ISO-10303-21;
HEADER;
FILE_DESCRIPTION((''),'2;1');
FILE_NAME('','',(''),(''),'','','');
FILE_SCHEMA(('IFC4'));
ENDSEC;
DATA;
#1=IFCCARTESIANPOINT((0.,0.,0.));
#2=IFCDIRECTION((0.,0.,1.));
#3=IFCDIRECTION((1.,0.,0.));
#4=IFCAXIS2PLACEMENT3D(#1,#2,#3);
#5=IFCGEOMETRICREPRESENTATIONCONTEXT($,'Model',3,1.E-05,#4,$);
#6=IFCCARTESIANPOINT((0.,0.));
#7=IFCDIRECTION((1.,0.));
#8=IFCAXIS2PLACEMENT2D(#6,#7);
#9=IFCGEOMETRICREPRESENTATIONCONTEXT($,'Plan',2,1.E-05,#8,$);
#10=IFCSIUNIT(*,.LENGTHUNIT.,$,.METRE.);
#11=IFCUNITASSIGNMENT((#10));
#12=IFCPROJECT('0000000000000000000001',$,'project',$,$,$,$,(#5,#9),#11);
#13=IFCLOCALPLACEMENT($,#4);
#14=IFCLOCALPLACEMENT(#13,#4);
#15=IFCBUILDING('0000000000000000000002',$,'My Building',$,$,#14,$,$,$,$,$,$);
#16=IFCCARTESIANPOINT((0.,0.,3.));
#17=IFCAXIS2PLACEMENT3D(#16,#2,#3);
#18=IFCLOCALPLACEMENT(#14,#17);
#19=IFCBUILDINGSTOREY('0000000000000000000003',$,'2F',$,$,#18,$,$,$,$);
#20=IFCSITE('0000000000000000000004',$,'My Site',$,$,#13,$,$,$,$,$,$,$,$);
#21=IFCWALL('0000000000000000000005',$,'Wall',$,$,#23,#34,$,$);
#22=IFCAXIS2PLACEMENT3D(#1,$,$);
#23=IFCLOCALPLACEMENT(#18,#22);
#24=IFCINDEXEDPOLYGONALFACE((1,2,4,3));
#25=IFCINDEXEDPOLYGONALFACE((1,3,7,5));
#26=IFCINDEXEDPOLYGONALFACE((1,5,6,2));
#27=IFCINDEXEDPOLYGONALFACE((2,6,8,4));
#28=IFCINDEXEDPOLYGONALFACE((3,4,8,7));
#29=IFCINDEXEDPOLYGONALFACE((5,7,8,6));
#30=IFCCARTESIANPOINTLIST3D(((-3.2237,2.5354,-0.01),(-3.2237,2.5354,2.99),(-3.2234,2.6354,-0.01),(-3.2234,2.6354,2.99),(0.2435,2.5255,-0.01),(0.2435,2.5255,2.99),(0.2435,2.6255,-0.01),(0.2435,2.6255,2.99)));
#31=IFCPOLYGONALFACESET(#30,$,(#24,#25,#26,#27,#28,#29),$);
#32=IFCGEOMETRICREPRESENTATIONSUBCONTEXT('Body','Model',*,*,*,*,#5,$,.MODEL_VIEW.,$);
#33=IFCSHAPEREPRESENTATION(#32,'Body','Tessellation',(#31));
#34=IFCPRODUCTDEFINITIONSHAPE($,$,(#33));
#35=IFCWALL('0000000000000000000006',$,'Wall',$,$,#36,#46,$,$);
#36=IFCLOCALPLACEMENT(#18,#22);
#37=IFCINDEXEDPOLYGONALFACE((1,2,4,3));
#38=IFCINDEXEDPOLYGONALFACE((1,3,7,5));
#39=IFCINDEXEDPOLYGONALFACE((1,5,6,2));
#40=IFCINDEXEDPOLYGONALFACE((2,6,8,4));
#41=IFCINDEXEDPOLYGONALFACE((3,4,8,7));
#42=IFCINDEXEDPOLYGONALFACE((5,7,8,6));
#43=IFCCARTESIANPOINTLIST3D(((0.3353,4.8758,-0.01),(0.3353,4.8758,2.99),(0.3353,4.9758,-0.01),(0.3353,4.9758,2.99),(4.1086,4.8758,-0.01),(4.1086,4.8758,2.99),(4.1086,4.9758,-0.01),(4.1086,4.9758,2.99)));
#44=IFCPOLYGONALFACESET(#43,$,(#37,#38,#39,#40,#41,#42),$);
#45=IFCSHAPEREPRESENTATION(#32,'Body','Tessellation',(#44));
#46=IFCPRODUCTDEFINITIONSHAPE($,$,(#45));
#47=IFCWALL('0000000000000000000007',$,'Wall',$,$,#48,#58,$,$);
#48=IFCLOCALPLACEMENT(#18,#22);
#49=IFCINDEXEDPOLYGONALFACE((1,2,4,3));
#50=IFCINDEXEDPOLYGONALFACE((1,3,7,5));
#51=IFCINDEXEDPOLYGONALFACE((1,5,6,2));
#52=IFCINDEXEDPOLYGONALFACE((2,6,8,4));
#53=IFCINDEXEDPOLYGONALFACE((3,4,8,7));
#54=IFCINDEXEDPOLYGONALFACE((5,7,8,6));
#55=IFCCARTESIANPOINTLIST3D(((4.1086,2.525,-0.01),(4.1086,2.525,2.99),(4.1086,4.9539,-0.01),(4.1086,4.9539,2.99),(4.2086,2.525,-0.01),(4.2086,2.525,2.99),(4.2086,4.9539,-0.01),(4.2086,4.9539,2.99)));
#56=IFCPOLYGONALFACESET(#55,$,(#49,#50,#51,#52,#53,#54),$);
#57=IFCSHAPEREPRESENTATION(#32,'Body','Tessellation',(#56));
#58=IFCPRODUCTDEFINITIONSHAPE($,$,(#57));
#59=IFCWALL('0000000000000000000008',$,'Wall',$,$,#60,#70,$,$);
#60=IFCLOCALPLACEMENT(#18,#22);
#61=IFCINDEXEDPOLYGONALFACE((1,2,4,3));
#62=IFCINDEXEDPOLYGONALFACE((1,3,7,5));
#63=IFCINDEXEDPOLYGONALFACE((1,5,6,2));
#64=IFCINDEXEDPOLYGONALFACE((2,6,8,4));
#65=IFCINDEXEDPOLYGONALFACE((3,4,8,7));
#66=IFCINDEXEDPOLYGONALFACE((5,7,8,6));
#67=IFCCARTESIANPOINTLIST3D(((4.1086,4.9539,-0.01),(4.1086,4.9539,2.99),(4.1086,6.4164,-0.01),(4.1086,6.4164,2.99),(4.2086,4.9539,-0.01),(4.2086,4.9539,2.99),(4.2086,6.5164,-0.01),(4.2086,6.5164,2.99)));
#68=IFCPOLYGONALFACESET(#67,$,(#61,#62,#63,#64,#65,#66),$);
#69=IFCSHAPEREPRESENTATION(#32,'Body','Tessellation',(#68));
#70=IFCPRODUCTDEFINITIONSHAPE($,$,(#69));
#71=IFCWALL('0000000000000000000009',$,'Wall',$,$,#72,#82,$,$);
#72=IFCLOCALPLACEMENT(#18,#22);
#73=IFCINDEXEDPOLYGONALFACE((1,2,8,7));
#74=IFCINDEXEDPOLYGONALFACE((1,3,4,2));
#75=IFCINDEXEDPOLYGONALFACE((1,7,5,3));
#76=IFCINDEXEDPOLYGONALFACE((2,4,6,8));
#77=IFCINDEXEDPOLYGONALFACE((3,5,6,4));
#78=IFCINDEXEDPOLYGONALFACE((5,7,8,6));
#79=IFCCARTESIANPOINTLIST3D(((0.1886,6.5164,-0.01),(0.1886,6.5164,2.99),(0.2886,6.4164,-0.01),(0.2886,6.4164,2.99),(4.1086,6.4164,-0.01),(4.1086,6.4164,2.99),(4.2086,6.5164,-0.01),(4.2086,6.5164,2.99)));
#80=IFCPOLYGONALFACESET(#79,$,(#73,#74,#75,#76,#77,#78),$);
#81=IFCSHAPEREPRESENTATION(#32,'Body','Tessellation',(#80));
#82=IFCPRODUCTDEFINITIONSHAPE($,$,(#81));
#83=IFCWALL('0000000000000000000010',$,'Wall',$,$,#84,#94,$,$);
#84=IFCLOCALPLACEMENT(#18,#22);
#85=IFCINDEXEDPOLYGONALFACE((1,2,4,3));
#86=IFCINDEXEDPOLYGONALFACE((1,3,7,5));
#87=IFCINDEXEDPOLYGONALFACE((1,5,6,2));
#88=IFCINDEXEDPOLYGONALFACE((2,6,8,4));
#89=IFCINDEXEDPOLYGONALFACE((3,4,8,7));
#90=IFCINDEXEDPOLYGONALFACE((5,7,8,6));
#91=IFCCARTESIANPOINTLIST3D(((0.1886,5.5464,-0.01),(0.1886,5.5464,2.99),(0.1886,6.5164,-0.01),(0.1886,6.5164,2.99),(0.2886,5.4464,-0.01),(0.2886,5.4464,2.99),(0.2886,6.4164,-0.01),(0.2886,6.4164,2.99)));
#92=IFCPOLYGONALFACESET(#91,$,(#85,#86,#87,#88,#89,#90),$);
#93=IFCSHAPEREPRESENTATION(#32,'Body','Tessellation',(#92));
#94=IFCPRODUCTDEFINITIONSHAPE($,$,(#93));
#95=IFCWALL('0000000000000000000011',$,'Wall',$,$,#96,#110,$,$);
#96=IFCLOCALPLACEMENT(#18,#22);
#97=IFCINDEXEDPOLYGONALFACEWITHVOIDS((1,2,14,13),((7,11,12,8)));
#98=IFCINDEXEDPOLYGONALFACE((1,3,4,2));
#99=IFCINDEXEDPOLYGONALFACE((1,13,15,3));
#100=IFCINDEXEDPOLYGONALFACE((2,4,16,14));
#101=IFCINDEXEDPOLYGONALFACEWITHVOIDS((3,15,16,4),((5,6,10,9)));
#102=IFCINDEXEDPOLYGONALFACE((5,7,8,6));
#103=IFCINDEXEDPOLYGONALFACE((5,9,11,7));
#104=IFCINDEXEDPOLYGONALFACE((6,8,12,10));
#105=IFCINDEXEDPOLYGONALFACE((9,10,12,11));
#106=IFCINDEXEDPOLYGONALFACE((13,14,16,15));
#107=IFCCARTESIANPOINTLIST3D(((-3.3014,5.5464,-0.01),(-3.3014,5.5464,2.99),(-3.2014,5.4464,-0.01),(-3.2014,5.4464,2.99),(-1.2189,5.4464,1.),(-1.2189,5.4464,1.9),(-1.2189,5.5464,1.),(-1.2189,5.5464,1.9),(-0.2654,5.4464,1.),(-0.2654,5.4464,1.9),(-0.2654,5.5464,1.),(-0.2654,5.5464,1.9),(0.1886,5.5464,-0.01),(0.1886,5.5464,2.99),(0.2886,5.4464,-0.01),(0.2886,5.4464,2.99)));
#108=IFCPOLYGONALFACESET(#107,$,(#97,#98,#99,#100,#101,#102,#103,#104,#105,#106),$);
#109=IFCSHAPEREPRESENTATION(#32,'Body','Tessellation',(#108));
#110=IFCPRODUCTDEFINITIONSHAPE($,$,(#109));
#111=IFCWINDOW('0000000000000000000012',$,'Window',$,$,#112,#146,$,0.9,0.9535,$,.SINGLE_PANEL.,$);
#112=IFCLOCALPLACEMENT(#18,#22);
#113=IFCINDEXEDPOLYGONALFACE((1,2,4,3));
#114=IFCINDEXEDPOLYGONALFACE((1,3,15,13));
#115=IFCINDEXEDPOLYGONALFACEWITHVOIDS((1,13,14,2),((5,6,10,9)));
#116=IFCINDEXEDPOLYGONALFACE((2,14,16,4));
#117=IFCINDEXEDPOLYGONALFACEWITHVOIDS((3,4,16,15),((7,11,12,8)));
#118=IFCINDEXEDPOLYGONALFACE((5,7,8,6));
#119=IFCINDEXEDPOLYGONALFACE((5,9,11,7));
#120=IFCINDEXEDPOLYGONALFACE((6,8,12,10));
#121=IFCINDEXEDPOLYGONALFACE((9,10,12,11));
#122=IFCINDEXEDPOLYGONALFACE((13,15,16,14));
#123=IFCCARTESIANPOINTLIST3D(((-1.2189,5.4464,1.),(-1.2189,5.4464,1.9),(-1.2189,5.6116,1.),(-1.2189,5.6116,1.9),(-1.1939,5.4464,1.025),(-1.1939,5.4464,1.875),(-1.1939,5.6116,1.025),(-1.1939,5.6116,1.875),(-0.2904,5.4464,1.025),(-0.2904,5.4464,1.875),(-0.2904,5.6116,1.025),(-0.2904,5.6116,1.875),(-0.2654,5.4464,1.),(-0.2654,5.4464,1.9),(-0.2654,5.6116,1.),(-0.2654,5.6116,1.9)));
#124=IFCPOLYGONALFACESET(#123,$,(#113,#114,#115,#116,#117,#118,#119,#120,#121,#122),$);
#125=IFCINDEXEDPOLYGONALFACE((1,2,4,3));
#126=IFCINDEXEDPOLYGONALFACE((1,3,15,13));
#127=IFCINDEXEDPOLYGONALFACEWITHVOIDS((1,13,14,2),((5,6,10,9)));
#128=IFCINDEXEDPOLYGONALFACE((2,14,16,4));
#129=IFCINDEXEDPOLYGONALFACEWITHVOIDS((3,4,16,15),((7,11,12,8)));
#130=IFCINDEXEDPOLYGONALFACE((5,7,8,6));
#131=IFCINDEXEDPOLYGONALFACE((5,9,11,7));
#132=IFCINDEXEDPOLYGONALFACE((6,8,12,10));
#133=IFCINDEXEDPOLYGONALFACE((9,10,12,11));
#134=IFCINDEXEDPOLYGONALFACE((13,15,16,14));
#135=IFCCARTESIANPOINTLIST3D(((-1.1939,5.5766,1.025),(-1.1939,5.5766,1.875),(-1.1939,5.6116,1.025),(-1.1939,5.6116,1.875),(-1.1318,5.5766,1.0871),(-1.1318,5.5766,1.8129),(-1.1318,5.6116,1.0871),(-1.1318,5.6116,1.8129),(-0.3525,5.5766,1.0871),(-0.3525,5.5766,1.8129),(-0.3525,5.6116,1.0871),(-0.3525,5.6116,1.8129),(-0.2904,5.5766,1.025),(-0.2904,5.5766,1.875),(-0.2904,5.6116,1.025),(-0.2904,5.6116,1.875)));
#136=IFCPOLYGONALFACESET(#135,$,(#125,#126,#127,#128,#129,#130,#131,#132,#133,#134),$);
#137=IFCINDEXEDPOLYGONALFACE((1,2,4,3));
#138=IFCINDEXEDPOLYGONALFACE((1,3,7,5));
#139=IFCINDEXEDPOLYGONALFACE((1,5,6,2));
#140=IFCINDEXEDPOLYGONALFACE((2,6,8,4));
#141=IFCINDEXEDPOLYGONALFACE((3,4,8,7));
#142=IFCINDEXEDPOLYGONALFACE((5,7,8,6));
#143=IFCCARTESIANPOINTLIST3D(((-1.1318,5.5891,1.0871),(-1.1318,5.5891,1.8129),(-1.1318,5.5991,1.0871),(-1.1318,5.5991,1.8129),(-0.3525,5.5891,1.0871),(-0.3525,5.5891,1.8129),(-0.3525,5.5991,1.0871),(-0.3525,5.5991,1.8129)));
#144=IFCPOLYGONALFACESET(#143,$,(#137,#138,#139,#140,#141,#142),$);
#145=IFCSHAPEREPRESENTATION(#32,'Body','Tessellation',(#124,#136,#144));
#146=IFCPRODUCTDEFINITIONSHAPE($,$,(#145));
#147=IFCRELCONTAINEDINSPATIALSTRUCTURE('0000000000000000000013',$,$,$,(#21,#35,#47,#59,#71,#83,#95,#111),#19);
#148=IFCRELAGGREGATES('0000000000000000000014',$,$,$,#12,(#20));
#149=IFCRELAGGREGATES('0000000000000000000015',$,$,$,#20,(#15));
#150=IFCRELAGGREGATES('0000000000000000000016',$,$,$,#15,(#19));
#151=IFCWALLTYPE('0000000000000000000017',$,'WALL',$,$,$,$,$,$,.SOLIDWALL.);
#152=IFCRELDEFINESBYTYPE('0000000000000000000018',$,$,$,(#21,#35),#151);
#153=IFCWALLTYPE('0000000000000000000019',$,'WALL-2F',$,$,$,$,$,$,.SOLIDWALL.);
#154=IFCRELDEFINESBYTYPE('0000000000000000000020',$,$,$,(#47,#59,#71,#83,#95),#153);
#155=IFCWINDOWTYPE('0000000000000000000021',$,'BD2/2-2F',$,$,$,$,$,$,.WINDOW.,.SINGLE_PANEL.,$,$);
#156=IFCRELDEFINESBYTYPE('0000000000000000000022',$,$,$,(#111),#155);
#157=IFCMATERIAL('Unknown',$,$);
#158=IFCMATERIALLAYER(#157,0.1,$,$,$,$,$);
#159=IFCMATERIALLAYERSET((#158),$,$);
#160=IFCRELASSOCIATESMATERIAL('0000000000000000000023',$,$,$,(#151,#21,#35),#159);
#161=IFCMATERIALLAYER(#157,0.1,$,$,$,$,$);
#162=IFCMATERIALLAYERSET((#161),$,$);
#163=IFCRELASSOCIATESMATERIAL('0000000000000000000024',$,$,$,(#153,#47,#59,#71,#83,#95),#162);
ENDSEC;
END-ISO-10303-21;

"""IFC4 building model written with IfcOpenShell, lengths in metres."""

from ifc_helpers import new_model, entity, si_unit, frame, origin_with_axes, origin_2d_with_axis, place, context, subcontext, project, spatial, line, indexed_curve, outline, extrude, shape, source, transform, mapped, material, layer, layer_set, layer_usage, type_object, type_shapes, element, fill, save


model = new_model("IFC4")

# Units and contexts
model_context = context("Model", 3, precision=1e-05, world=origin_with_axes())
plan_context = context("Plan", 2, precision=1e-05, world=origin_2d_with_axis())
body_context_1 = subcontext(model_context, "Body", "Model", "MODEL_VIEW")
body_context_2 = subcontext(plan_context, "Body", "Plan", "PLAN_VIEW")
ifc_project = project(units=[si_unit("LENGTHUNIT", "METRE")], contexts=[model_context, plan_context])

# Site, building, storey
site_placement = place(None, origin_with_axes())
site = spatial("IfcSite", under=ifc_project, at=site_placement, Name="My Site")
building_placement = place(site_placement, origin_with_axes())
building = spatial("IfcBuilding", under=site, at=building_placement, Name="My Building")
storey_placement = place(building_placement, frame((0.0, 0.0, 3.0), z_axis=(0.0, 0.0, 1.0), x_axis=(1.0, 0.0, 0.0)))
storey = spatial("IfcBuildingStorey", under=building, at=storey_placement, Name="2F")

# Shared definitions
ifc_material = material(Name="Unknown")

# Shared definitions
ifc_layer_1 = layer(ifc_material, 0.1)
ifc_layer_set_1 = layer_set([ifc_layer_1])
wall_type_1 = type_object("IfcWallType", Name="WALL", PredefinedType="SOLIDWALL", material=ifc_layer_set_1)

# Walls
ifc_layer_usage_1 = layer_usage(ifc_layer_set_1, "AXIS2", "POSITIVE", 0.0)
wall_1_placement = place(storey_placement, frame((-3.2237, 2.5354, -0.01), z_axis=(0.0, 0.0, 1.0), x_axis=(0.999996, -0.002859, 0.0)))
element("IfcWall", 1, at=wall_1_placement, inside=storey, type_object=wall_type_1, material=ifc_layer_usage_1, Name="Wall", context=body_context_1, shape_type="SweptSolid", body=[
    extrude(outline(indexed_curve([(0.0, 0.0), (0.0, 0.1), (3.4669, 0.1), (3.4672, 0.0)], segments=[line(1, 2, 3, 4, 1)])), origin_with_axes(), (0.0, 0.0, 1.0), 3.0),
])
ifc_layer_usage_2 = layer_usage(ifc_layer_set_1, "AXIS2", "POSITIVE", 0.0)
wall_2_placement = place(storey_placement, frame((0.3353, 4.8758, -0.01), z_axis=(0.0, 0.0, 1.0), x_axis=(1.0, 0.0, 0.0)))
element("IfcWall", 2, at=wall_2_placement, inside=storey, type_object=wall_type_1, material=ifc_layer_usage_2, Name="Wall", context=body_context_1, shape_type="SweptSolid", body=[
    extrude(outline(indexed_curve([(0.0, 0.0), (0.0, 0.1), (3.7733, 0.1), (3.7733, 0.0)], segments=[line(1, 2, 3, 4, 1)])), origin_with_axes(), (0.0, 0.0, 1.0), 3.0),
])
ifc_layer_2 = layer(ifc_material, 0.1)
ifc_layer_set_2 = layer_set([ifc_layer_2])
ifc_layer_usage_3 = layer_usage(ifc_layer_set_2, "AXIS2", "POSITIVE", 0.0)
wall_type_2 = type_object("IfcWallType", Name="WALL-2F", PredefinedType="SOLIDWALL", material=ifc_layer_set_2)
wall_3_placement = place(storey_placement, frame((4.2086, 2.525, -0.01), z_axis=(0.0, 0.0, 1.0), x_axis=(0.0, 1.0, 0.0)))
element("IfcWall", 3, at=wall_3_placement, inside=storey, type_object=wall_type_2, material=ifc_layer_usage_3, Name="Wall", context=body_context_1, shape_type="SweptSolid", body=[
    extrude(outline(indexed_curve([(0.0, 0.0), (0.0, 0.1), (2.4288, 0.1), (2.4288, 0.0)], segments=[line(1, 2, 3, 4, 1)])), origin_with_axes(), (0.0, 0.0, 1.0), 3.0),
])
ifc_layer_usage_4 = layer_usage(ifc_layer_set_2, "AXIS2", "POSITIVE", 0.0)
wall_4_placement = place(storey_placement, frame((4.2086, 4.9539, -0.01), z_axis=(0.0, 0.0, 1.0), x_axis=(0.0, 1.0, 0.0)))
element("IfcWall", 4, at=wall_4_placement, inside=storey, type_object=wall_type_2, material=ifc_layer_usage_4, Name="Wall", context=body_context_1, shape_type="SweptSolid", body=[
    extrude(outline(indexed_curve([(0.0, 0.0), (0.0, 0.1), (1.4626, 0.1), (1.5626, 0.0)], segments=[line(1, 2, 3, 4, 1)])), origin_with_axes(), (0.0, 0.0, 1.0), 3.0),
])
ifc_layer_usage_5 = layer_usage(ifc_layer_set_2, "AXIS2", "POSITIVE", 0.0)
wall_5_placement = place(storey_placement, frame((4.2086, 6.5164, -0.01), z_axis=(0.0, 0.0, 1.0), x_axis=(-1.0, 0.0, 0.0)))
element("IfcWall", 5, at=wall_5_placement, inside=storey, type_object=wall_type_2, material=ifc_layer_usage_5, Name="Wall", context=body_context_1, shape_type="SweptSolid", body=[
    extrude(outline(indexed_curve([(0.0, 0.0), (0.1, 0.1), (3.92, 0.1), (4.02, 0.0)], segments=[line(1, 2, 3, 4, 1)])), origin_with_axes(), (0.0, 0.0, 1.0), 3.0),
])
ifc_layer_usage_6 = layer_usage(ifc_layer_set_2, "AXIS2", "POSITIVE", 0.0)
wall_6_placement = place(storey_placement, frame((0.1886, 6.5164, -0.01), z_axis=(0.0, 0.0, 1.0), x_axis=(0.0, -1.0, 0.0)))
element("IfcWall", 6, at=wall_6_placement, inside=storey, type_object=wall_type_2, material=ifc_layer_usage_6, Name="Wall", context=body_context_1, shape_type="SweptSolid", body=[
    extrude(outline(indexed_curve([(0.0, 0.0), (0.1, 0.1), (1.07, 0.1), (0.97, 0.0)], segments=[line(1, 2, 3, 4, 1)])), origin_with_axes(), (0.0, 0.0, 1.0), 3.0),
])

# Wall, opening, window
ifc_layer_usage_7 = layer_usage(ifc_layer_set_2, "AXIS2", "POSITIVE", 0.0)
wall_7_placement = place(storey_placement, frame((0.1886, 5.5464, -0.01), z_axis=(0.0, 0.0, 1.0), x_axis=(-1.0, 0.0, 0.0)))
wall_7 = element("IfcWall", 7, at=wall_7_placement, inside=storey, type_object=wall_type_2, material=ifc_layer_usage_7, Name="Wall", context=body_context_1, shape_type="SweptSolid", body=[
    extrude(outline(indexed_curve([(0.0, 0.0), (-0.1, 0.1), (3.39, 0.1), (3.49, 0.0)], segments=[line(1, 2, 3, 4, 1)])), origin_with_axes(), (0.0, 0.0, 1.0), 3.0),
])
shared_shape_1 = source(origin_with_axes(), body_context_1, "Body", "SweptSolid", [
    extrude(outline(indexed_curve([(0.0, 0.0), (0.9535, 0.0), (0.9535, 0.9), (0.0, 0.9)], segments=[line(1, 2, 3, 4, 1)])), frame((0.0, -0.6, 0.0), z_axis=(0.0, -1.0, 0.0), x_axis=(1.0, 0.0, 0.0)), (0.0, 0.0, -1.0), 1.2),
])
opening_1_placement = place(wall_7_placement, frame((0.454, 0.0, 1.01), z_axis=(0.0, 0.0, 1.0), x_axis=(1.0, 0.0, 0.0)))
opening_1 = element("IfcOpeningElement", 8, at=opening_1_placement, cuts=wall_7, PredefinedType="OPENING", context=body_context_1, shape_type="MappedRepresentation", body=[
    mapped(shared_shape_1, transform((0.0, 0.0, 0.0), x_axis=(1.0, 0.0, 0.0), y_axis=(0.0, 1.0, 0.0), z_axis=(0.0, 0.0, 1.0), scale=1.0)),
])
window_type_1 = type_object("IfcWindowType", Name="BD2/2-2F", PartitioningType="SINGLE_PANEL", PredefinedType="WINDOW")
shared_shape_2 = source(origin_with_axes(), body_context_1, "Body", "SweptSolid", [
    extrude(outline(indexed_curve([(0.0, 0.0), (0.9535, 0.0), (0.9535, 0.9), (0.0, 0.9)], segments=[line(1, 2, 3, 4, 1)]), holes=[indexed_curve([(0.025, 0.025), (0.9285, 0.025), (0.9285, 0.875), (0.025, 0.875)], segments=[line(1, 2, 3, 4, 1)])]), frame((0.0, -0.0651, 0.0), z_axis=(0.0, -1.0, 0.0), x_axis=(1.0, 0.0, 0.0)), (0.0, 0.0, -1.0), 0.1651),
    extrude(outline(indexed_curve([(0.0, 0.0), (0.9535, 0.0), (0.9535, 0.9), (0.0, 0.9)], segments=[line(1, 2, 3, 4, 1)]), holes=[indexed_curve([(0.708, 0.708), (0.2455, 0.708), (0.2455, 0.192), (0.708, 0.192)], segments=[line(1, 2, 3, 4, 1)])]), frame((0.0, 0.05, 0.0), z_axis=(0.0, -1.0, 0.0), x_axis=(1.0, 0.0, 0.0)), (0.0, 0.0, -1.0), -0.1151),
    extrude(outline(indexed_curve([(0.0, 0.0), (0.9035, 0.0), (0.9035, 0.85), (0.0, 0.85)], segments=[line(1, 2, 3, 4, 1)]), holes=[indexed_curve([(0.0621, 0.0621), (0.8414, 0.0621), (0.8414, 0.7879), (0.0621, 0.7879)], segments=[line(1, 2, 3, 4, 1)])]), frame((0.025, -0.0651, 0.025), z_axis=(0.0, -1.0, 0.0), x_axis=(1.0, 0.0, 0.0)), (0.0, 0.0, -1.0), 0.035),
    extrude(outline(indexed_curve([(0.0621, 0.0621), (0.8414, 0.0621), (0.8414, 0.7879), (0.0621, 0.7879)], segments=[line(1, 2, 3, 4, 1)])), frame((0.025, -0.0526, 0.025), z_axis=(0.0, -1.0, 0.0), x_axis=(1.0, 0.0, 0.0)), (0.0, 0.0, -1.0), 0.01),
])
shared_shape_3 = source(origin_with_axes(), body_context_2, "Body", "Curve2D", [
    entity("IfcIndexedPolyCurve", entity("IfcCartesianPointList2D", [[0.708, 0.05], [0.2455, 0.05]])),
    entity("IfcIndexedPolyCurve", entity("IfcCartesianPointList2D", [[0.0, 0.1], [0.025, 0.1], [0.025, -0.0651], [0.708, -0.0651], [0.708, 0.05], [0.0, 0.05]]), [entity("IfcLineIndex", [1, 2, 3, 4, 5, 6, 1])]),
    entity("IfcIndexedPolyCurve", entity("IfcCartesianPointList2D", [[0.9535, 0.1], [0.9285, 0.1], [0.9285, -0.0651], [0.2455, -0.0651], [0.2455, 0.05], [0.9535, 0.05]]), [entity("IfcLineIndex", [1, 2, 3, 4, 5, 6, 1])]),
    entity("IfcIndexedPolyCurve", entity("IfcCartesianPointList2D", [[0.025, -0.0651], [0.0871, -0.0651], [0.0871, -0.0301], [0.025, -0.0301]]), [entity("IfcLineIndex", [1, 2, 3, 4, 1])]),
    entity("IfcIndexedPolyCurve", entity("IfcCartesianPointList2D", [[0.9285, -0.0651], [0.8664, -0.0651], [0.8664, -0.0301], [0.9285, -0.0301]]), [entity("IfcLineIndex", [1, 2, 3, 4, 1])]),
    entity("IfcIndexedPolyCurve", entity("IfcCartesianPointList2D", [[0.0871, -0.0651], [0.8664, -0.0651]])),
    entity("IfcIndexedPolyCurve", entity("IfcCartesianPointList2D", [[0.0871, -0.0301], [0.8664, -0.0301]])),
    entity("IfcIndexedPolyCurve", entity("IfcCartesianPointList2D", [[0.0871, -0.0476], [0.8664, -0.0476]])),
])
type_shapes(window_type_1, [shared_shape_2, shared_shape_3])
window_1_placement = place(opening_1_placement, frame((0.0, 0.0, 0.0), z_axis=(0.0, 0.0, 1.0), x_axis=(1.0, 0.0, 0.0)))
window_1 = element("IfcWindow", 9, at=window_1_placement, inside=storey, type_object=window_type_1, Name="Window", OverallHeight=0.9, OverallWidth=0.9535, PartitioningType="SINGLE_PANEL", shapes=[
    shape(body_context_1, "Body", "MappedRepresentation", [mapped(shared_shape_2, transform((0.0, 0.0, 0.0), x_axis=(1.0, 0.0, 0.0), y_axis=(0.0, 1.0, 0.0), z_axis=(0.0, 0.0, 1.0), scale=1.0))]),
    shape(body_context_2, "Body", "MappedRepresentation", [mapped(shared_shape_3, transform((0.0, 0.0, 0.0), x_axis=(1.0, 0.0, 0.0), y_axis=(0.0, 1.0, 0.0), z_axis=(0.0, 0.0, 1.0), scale=1.0))]),
])
fill(opening_1, window_1)

save(model, "model.ifc")
